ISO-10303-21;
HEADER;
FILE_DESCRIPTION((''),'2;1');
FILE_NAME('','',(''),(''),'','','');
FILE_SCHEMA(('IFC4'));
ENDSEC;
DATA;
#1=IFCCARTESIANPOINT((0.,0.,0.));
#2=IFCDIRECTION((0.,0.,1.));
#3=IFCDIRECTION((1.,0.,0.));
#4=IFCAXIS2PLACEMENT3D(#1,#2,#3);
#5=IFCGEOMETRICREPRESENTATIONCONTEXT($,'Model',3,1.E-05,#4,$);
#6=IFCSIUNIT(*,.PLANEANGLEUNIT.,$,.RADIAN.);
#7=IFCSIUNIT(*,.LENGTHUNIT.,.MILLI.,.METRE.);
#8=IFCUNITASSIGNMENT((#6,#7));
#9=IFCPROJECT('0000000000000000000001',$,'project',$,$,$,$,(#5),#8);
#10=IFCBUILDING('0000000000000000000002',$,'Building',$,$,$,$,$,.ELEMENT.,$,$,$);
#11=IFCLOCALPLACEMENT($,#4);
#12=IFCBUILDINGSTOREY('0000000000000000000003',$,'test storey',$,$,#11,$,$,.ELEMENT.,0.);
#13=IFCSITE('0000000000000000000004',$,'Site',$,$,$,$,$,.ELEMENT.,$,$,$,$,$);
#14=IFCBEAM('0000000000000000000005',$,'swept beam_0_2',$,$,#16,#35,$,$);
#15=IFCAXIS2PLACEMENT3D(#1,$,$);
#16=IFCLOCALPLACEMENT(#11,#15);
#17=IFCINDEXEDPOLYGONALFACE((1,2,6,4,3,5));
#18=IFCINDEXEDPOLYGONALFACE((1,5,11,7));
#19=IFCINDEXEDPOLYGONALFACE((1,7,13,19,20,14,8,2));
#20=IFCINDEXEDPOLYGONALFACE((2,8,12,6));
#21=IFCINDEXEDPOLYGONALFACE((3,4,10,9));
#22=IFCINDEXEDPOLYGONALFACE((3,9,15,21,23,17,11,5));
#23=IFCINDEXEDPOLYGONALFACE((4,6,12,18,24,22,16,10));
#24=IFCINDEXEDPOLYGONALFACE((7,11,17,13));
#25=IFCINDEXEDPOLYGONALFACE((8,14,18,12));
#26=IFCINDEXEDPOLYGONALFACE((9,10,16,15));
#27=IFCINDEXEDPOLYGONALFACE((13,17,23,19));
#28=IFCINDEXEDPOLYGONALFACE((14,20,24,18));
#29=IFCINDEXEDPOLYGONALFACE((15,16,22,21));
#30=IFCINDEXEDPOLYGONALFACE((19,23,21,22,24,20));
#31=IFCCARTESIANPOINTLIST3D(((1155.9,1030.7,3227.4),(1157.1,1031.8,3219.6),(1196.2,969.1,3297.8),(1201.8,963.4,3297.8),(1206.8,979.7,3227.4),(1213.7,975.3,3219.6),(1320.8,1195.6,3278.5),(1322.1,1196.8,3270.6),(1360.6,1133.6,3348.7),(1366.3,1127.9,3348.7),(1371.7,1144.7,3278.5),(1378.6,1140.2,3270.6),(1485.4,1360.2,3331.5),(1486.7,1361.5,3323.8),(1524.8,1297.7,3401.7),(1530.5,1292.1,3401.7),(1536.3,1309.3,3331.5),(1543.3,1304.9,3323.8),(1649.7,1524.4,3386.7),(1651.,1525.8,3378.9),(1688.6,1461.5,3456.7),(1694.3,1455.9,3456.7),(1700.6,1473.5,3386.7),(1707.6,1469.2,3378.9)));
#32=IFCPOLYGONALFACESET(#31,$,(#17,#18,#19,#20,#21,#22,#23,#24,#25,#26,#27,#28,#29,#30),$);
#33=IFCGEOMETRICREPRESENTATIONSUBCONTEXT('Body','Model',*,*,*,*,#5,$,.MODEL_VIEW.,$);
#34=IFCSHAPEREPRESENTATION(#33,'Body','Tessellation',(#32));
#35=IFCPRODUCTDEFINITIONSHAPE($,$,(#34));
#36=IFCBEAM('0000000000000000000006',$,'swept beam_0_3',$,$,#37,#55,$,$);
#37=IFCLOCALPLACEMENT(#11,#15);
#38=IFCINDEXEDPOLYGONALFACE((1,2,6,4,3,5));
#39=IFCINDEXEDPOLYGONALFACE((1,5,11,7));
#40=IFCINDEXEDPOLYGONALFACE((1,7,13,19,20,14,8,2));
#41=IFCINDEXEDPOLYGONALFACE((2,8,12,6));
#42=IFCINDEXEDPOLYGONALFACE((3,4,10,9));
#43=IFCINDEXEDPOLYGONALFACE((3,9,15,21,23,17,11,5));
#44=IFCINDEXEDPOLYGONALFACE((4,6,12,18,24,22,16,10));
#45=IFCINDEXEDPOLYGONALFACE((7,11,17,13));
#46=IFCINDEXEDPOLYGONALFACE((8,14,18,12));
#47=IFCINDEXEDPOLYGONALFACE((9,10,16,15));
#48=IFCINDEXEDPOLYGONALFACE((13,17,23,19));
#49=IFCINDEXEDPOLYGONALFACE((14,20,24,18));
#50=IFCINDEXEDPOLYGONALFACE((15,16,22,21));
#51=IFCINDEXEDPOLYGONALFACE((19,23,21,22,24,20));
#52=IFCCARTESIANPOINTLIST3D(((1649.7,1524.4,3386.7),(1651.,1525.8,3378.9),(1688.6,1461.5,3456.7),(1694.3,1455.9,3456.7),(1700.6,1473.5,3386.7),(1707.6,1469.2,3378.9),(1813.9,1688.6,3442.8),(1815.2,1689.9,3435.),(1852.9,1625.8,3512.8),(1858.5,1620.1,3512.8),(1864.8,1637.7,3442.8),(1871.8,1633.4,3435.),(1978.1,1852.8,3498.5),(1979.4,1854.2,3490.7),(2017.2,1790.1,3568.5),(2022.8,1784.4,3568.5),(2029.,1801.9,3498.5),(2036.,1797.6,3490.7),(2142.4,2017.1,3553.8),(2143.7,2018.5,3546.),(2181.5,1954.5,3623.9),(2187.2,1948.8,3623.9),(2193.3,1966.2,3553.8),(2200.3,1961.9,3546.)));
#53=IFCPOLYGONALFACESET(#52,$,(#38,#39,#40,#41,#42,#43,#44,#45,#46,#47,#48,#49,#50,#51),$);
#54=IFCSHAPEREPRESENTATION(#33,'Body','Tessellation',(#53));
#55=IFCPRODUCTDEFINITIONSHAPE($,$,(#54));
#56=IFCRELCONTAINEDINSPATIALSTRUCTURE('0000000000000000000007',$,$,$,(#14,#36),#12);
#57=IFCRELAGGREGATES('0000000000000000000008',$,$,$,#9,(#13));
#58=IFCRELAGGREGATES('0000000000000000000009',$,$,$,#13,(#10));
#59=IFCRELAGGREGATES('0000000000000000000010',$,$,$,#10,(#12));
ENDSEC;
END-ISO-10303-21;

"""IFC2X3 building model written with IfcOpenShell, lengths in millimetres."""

from ifc_helpers import new_model, entity, si_unit, origin_with_axes, place, context, subcontext, project, spatial, element, save


model = new_model("IFC2X3")

# Units and contexts
model_context = context("Model", 3, precision=1e-05, world=origin_with_axes())
body_context = subcontext(model_context, "Body", "Model", "MODEL_VIEW")
ifc_project = project(units=[si_unit("PLANEANGLEUNIT", "RADIAN"), si_unit("LENGTHUNIT", "METRE", prefix="MILLI")], contexts=[model_context])

# Site, building, storey
site = spatial("IfcSite", under=ifc_project, Name="Site", CompositionType="ELEMENT")
building = spatial("IfcBuilding", under=site, Name="Building", CompositionType="ELEMENT")
storey_placement = place(None, origin_with_axes())
storey = spatial("IfcBuildingStorey", under=building, at=storey_placement, Name="test storey", CompositionType="ELEMENT", Elevation=0.0)

# Beams
beam_1_placement = place(storey_placement, origin_with_axes())
element("IfcBeam", 1, at=beam_1_placement, inside=storey, Name="swept beam_0_2", context=body_context, shape_type="SweptSolid", body=[
    entity("IfcRevolvedAreaSolid", entity("IfcArbitraryClosedProfileDef", "AREA", None, entity("IfcPolyline", [entity("IfcCartesianPoint", [-80.0, 40.0]), entity("IfcCartesianPoint", [-80.0, 32.0]), entity("IfcCartesianPoint", [-8.0, 32.0]), entity("IfcCartesianPoint", [-8.0, -40.0]), entity("IfcCartesianPoint", [0.0, -40.0]), entity("IfcCartesianPoint", [0.0, 40.0]), entity("IfcCartesianPoint", [-80.0, 40.0])])), entity("IfcAxis2Placement3D", entity("IfcCartesianPoint", [1185.4, 1003.6, 3219.6]), entity("IfcDirection", [-0.6914, -0.6914, -0.2093]), entity("IfcDirection", [0.148, 0.148, -0.9778])), entity("IfcAxis1Placement", entity("IfcCartesianPoint", [-26799.5, 0.0, 0.0]), entity("IfcDirection", [0.0, 1.0, 0.0])), 0.026735),
])
beam_2_placement = place(storey_placement, origin_with_axes())
element("IfcBeam", 2, at=beam_2_placement, inside=storey, Name="swept beam_0_3", context=body_context, shape_type="SweptSolid", body=[
    entity("IfcRevolvedAreaSolid", entity("IfcArbitraryClosedProfileDef", "AREA", None, entity("IfcPolyline", [entity("IfcCartesianPoint", [80.0, -40.0]), entity("IfcCartesianPoint", [80.0, -32.0]), entity("IfcCartesianPoint", [8.0, -32.0]), entity("IfcCartesianPoint", [8.0, 40.0]), entity("IfcCartesianPoint", [0.0, 40.0]), entity("IfcCartesianPoint", [0.0, -40.0]), entity("IfcCartesianPoint", [80.0, -40.0])])), entity("IfcAxis2Placement3D", entity("IfcCartesianPoint", [1679.3, 1497.5, 3378.9]), entity("IfcDirection", [-0.6872, -0.6872, -0.2354]), entity("IfcDirection", [-0.1664, -0.1664, 0.9719])), entity("IfcAxis1Placement", entity("IfcCartesianPoint", [-157115.6, 0.0, 0.0]), entity("IfcDirection", [0.0, 1.0, 0.0])), 0.00456),
])

save(model, "model.ifc")
